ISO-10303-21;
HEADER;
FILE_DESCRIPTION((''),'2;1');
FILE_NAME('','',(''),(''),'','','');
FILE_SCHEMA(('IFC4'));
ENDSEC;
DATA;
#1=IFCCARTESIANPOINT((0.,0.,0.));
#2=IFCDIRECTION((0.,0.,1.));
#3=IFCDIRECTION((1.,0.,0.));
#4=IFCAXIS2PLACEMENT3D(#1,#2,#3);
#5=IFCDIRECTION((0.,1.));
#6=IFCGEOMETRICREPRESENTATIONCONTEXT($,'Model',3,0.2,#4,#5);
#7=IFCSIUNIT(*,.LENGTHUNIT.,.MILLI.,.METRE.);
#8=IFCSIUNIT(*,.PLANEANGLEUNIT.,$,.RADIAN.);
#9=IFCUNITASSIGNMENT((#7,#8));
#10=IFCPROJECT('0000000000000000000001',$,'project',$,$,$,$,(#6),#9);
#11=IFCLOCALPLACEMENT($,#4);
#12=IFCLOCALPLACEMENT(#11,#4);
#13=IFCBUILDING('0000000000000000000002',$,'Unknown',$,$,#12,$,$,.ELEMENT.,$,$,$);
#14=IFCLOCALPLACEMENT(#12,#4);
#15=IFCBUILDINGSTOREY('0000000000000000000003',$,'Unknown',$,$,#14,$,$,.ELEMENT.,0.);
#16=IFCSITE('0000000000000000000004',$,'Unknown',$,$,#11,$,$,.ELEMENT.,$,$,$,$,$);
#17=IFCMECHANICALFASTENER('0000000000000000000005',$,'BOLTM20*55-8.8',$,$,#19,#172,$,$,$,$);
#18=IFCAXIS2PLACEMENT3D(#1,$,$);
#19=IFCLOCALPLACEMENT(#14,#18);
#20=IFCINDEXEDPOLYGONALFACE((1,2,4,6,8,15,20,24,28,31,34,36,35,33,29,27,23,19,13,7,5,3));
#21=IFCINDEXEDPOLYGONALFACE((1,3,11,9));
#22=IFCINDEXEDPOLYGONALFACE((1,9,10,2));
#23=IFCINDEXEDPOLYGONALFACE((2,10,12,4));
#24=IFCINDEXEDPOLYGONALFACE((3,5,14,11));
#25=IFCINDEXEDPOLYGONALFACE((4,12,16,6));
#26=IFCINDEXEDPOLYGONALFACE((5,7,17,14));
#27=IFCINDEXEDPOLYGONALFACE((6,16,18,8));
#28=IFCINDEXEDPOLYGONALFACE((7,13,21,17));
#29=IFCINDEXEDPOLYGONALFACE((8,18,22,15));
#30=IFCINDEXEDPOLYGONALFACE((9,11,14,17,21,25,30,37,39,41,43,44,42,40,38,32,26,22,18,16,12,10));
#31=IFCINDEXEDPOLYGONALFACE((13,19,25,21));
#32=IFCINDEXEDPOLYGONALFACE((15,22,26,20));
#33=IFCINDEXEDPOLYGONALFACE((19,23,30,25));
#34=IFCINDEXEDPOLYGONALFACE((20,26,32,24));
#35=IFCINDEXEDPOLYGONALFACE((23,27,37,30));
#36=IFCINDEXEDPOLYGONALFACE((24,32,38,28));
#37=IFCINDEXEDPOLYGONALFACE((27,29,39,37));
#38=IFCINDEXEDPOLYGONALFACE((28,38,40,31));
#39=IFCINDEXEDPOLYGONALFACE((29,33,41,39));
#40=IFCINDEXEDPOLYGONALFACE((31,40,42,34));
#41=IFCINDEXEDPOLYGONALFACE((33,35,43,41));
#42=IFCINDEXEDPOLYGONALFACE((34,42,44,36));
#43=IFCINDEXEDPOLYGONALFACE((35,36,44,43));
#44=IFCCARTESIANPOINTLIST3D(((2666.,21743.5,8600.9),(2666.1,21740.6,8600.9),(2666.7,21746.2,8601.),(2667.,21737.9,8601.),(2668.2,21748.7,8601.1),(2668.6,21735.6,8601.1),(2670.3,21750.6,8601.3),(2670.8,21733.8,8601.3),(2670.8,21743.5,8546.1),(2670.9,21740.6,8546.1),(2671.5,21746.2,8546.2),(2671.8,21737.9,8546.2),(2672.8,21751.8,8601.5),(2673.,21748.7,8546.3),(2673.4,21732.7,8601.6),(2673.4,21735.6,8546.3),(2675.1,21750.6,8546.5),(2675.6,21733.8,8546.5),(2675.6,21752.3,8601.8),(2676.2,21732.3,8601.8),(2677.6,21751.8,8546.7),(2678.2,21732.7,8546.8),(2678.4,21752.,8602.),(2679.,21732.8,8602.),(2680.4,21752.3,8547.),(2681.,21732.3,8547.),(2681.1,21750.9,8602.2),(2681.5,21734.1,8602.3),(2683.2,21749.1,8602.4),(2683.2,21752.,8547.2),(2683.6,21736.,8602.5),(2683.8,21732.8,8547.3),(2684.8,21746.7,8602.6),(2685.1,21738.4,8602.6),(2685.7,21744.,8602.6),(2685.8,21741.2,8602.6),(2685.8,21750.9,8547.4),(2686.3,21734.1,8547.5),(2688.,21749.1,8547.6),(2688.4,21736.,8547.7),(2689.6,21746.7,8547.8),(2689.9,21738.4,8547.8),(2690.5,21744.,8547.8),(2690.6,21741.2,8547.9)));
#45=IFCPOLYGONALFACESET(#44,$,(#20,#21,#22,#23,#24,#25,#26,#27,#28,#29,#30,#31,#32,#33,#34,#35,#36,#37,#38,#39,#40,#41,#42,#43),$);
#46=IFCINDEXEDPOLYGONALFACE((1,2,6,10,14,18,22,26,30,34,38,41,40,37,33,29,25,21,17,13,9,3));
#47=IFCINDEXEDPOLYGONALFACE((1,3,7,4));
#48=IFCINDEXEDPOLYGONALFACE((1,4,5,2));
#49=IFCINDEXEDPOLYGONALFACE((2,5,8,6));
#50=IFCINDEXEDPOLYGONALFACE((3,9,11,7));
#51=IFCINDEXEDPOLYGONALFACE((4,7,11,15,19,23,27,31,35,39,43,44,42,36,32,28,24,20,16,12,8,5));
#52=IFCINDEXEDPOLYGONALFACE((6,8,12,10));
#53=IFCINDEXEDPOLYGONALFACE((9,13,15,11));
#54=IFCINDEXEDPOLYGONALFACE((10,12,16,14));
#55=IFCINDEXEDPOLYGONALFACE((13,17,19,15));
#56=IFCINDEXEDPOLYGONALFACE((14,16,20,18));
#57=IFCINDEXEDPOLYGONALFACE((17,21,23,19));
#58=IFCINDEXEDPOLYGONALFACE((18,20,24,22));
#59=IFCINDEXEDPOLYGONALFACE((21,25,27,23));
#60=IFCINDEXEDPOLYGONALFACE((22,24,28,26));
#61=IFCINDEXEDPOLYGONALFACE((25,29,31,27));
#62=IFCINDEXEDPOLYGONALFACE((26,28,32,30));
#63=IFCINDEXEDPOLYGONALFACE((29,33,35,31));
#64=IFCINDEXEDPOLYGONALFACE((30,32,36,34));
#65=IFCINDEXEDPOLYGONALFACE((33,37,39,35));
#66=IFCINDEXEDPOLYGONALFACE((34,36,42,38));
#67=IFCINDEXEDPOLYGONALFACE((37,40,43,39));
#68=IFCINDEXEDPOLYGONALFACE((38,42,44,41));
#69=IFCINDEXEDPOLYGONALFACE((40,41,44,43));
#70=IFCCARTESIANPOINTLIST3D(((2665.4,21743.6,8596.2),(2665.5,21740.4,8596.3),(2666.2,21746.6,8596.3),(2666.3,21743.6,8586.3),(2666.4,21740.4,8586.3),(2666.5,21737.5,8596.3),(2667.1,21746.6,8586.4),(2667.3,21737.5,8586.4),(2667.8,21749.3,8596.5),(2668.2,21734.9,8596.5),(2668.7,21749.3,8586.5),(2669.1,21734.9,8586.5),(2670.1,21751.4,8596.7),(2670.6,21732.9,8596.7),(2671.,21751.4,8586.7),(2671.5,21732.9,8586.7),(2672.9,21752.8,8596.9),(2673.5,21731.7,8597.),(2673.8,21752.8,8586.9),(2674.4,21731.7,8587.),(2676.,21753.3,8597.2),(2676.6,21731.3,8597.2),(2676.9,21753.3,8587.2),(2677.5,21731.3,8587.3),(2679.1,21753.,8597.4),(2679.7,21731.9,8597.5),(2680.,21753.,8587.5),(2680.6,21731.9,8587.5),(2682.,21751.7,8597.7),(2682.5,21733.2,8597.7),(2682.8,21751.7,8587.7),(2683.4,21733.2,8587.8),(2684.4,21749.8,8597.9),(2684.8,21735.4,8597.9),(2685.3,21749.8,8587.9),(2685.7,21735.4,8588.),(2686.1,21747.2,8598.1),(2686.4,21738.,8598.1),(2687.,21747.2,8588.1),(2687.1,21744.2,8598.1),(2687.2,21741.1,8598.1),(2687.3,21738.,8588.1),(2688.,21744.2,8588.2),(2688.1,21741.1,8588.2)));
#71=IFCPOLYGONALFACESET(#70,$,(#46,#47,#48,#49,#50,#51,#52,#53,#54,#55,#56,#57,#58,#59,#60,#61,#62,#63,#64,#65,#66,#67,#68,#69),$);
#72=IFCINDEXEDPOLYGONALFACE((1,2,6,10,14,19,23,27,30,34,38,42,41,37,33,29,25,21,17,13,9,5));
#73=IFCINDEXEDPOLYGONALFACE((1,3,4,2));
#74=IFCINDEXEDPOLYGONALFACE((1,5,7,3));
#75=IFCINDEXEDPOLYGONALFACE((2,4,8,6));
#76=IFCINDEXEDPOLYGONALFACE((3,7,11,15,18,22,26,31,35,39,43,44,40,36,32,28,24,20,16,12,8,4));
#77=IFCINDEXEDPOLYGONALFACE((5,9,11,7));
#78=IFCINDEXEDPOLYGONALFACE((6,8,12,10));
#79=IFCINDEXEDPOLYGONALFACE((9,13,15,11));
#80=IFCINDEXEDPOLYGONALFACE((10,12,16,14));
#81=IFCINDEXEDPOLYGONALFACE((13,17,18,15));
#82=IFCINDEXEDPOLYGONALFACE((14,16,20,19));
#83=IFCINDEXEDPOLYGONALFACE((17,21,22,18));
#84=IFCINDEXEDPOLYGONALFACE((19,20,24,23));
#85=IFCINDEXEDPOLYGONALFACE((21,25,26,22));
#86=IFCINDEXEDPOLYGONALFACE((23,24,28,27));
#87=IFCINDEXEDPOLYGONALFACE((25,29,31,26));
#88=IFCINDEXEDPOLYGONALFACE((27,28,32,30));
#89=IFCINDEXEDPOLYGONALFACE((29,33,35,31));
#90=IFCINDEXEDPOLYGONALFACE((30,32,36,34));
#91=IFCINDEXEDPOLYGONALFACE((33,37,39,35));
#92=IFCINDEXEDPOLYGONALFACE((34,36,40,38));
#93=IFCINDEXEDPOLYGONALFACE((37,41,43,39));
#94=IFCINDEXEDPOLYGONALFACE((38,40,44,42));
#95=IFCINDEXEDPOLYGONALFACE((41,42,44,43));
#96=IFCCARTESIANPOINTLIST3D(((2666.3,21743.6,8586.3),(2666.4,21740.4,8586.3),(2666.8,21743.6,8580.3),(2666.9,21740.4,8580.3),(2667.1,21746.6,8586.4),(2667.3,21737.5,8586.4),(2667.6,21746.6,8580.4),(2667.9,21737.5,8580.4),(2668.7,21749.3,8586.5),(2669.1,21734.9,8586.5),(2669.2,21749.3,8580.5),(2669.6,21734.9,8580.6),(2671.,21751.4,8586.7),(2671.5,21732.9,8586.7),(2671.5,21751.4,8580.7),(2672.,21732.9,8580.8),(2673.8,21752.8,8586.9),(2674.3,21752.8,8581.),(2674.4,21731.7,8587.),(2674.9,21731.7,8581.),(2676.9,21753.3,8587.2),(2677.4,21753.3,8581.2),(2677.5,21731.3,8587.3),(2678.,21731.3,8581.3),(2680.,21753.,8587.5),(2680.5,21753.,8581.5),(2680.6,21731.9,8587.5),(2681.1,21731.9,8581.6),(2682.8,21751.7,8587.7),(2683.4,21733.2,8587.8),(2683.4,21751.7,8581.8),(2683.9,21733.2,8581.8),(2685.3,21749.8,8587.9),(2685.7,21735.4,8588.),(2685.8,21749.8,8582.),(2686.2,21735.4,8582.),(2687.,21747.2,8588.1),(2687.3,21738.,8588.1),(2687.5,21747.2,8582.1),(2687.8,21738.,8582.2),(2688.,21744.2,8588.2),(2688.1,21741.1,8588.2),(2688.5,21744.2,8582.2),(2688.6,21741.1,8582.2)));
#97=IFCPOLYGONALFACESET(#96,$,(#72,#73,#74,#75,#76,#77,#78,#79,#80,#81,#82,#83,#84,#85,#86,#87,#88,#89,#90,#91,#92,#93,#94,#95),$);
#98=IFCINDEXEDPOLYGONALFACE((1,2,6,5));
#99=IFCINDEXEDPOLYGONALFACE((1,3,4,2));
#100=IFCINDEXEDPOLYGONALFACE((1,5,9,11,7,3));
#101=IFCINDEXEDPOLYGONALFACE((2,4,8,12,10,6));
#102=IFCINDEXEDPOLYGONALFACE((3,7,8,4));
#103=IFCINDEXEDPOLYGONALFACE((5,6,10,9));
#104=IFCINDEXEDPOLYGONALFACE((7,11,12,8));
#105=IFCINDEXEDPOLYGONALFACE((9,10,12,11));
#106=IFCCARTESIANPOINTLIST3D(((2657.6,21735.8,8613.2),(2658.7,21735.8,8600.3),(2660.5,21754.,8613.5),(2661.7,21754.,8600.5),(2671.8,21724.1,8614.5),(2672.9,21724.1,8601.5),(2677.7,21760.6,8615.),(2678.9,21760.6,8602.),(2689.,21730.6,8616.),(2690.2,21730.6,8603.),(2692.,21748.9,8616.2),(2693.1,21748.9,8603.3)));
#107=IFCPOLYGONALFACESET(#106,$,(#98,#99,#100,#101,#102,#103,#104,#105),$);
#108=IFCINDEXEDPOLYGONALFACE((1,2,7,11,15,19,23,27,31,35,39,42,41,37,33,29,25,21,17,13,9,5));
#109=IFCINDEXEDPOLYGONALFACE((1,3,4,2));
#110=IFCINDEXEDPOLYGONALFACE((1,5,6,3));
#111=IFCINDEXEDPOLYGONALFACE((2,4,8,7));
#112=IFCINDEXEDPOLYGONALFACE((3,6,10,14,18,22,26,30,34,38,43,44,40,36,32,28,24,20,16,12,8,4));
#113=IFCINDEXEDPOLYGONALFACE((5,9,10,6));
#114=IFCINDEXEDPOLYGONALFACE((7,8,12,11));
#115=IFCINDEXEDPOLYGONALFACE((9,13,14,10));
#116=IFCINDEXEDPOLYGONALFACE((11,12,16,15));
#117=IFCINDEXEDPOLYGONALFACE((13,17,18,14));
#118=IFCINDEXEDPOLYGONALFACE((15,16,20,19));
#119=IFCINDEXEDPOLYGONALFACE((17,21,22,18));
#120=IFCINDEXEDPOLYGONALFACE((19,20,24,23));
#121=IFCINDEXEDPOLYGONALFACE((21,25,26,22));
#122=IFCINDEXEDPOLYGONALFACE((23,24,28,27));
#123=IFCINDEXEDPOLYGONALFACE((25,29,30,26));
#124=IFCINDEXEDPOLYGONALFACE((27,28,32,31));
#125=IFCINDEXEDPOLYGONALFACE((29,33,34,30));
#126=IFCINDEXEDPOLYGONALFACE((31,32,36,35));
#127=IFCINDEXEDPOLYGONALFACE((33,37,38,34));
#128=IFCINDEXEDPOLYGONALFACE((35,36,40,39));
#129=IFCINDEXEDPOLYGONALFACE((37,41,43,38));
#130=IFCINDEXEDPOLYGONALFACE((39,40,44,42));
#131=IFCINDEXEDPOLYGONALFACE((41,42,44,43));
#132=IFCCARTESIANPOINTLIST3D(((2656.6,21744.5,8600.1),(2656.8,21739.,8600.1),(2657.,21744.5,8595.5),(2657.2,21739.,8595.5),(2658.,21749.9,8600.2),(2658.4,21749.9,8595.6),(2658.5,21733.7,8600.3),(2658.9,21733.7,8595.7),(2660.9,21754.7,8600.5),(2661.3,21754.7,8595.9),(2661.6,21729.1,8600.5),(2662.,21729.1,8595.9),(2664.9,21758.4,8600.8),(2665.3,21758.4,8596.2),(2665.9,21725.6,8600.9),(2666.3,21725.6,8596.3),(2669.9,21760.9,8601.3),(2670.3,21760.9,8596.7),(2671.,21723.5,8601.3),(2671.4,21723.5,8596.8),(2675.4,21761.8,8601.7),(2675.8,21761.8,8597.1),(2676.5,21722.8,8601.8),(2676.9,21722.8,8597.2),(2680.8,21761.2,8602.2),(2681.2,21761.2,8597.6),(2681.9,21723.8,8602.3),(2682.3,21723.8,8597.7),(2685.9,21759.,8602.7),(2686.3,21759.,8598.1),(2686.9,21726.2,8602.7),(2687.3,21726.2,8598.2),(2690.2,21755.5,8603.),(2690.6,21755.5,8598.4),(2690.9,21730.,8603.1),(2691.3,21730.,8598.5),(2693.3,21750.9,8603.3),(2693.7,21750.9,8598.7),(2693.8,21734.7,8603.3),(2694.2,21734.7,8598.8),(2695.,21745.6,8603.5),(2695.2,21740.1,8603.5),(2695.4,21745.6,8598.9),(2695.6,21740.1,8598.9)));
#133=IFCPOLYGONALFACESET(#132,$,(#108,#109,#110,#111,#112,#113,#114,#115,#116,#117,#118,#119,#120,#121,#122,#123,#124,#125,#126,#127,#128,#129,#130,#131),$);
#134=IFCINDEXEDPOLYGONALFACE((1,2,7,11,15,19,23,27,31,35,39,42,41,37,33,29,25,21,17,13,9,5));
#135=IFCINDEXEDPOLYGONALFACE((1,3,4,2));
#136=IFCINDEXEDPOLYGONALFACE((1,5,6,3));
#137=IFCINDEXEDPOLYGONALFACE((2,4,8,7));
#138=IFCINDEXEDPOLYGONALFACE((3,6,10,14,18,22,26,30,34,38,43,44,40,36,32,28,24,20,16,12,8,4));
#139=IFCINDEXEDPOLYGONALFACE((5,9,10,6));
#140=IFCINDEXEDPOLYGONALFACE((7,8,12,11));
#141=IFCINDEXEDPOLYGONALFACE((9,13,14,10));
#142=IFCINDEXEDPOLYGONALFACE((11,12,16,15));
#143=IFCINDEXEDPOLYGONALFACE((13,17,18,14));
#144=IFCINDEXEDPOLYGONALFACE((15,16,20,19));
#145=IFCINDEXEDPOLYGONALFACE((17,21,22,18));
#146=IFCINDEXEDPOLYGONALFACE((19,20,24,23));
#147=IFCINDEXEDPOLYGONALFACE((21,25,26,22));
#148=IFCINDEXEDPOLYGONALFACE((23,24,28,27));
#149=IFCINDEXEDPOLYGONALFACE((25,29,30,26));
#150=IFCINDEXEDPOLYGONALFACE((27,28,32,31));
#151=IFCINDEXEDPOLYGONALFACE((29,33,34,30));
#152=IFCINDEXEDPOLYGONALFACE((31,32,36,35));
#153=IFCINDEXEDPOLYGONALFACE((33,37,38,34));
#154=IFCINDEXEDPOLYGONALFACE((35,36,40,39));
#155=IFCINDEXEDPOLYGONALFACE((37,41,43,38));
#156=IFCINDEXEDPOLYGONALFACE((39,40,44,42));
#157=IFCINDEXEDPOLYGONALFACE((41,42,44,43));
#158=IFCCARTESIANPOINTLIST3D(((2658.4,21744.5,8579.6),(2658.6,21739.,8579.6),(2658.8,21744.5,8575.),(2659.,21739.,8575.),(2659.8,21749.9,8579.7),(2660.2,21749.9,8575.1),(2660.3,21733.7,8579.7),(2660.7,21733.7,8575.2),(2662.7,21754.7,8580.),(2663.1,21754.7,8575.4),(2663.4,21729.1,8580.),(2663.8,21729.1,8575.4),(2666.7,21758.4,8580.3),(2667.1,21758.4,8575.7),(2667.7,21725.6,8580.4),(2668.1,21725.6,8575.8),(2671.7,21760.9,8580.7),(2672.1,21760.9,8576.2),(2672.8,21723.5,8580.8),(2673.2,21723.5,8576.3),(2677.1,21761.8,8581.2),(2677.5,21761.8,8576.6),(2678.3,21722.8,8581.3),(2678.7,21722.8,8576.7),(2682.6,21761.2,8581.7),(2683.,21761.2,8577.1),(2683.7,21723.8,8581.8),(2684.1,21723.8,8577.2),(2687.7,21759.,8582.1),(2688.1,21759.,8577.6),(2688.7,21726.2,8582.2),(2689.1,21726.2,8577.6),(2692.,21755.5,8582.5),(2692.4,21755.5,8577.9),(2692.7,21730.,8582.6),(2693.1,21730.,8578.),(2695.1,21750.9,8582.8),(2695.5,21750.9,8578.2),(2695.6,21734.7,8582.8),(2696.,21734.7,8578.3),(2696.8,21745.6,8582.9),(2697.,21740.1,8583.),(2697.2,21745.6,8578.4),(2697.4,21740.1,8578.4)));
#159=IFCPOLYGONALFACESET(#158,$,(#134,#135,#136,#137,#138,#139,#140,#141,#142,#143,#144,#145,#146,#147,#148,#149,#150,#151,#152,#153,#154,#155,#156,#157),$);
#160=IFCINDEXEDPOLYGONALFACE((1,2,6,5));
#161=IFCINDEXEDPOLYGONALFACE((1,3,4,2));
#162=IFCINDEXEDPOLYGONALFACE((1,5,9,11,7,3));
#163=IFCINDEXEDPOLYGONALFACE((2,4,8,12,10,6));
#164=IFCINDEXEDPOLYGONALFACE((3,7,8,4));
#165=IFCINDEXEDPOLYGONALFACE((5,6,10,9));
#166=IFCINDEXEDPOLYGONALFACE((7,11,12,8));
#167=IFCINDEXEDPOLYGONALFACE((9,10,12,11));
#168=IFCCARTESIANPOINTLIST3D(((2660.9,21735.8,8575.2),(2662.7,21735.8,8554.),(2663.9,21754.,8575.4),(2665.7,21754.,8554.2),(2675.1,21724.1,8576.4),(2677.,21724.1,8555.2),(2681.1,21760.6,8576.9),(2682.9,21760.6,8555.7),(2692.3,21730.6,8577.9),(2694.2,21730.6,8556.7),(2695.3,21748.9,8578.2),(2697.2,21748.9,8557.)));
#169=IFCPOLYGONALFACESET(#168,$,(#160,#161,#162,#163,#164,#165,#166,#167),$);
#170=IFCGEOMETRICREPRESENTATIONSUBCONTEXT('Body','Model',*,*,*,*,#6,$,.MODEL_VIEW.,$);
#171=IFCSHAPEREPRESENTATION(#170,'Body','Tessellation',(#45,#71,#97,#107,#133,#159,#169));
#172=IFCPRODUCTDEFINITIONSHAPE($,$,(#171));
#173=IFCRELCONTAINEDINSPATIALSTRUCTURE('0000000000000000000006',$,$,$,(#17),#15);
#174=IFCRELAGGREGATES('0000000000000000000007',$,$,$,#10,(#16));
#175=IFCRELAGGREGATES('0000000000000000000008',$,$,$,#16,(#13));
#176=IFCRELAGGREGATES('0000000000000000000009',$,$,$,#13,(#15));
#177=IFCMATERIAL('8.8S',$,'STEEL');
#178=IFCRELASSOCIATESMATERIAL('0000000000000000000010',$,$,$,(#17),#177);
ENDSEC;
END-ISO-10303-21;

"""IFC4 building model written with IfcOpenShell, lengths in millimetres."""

from ifc_helpers import new_model, si_unit, direction, frame, origin_with_axes, place, context, subcontext, project, spatial, line, arc, indexed_curve, outline, extrude, source, transform, mapped, material, element, save


model = new_model("IFC4")

# Units and contexts
model_context = context("Model", 3, precision=0.2, world=origin_with_axes(), true_north=direction((0.0, 1.0)))
body_context = subcontext(model_context, "Body", "Model", "MODEL_VIEW")
ifc_project = project(units=[si_unit("LENGTHUNIT", "METRE", prefix="MILLI"), si_unit("PLANEANGLEUNIT", "RADIAN")], contexts=[model_context])

# Site, building, storey
site_placement = place(None, origin_with_axes())
site = spatial("IfcSite", under=ifc_project, at=site_placement, Name="Unknown", CompositionType="ELEMENT")
building_placement = place(site_placement, origin_with_axes())
building = spatial("IfcBuilding", under=site, at=building_placement, Name="Unknown", CompositionType="ELEMENT")
storey_placement = place(building_placement, origin_with_axes())
storey = spatial("IfcBuildingStorey", under=building, at=storey_placement, Name="Unknown", CompositionType="ELEMENT", Elevation=0.0)

# Mechanical fastener
ifc_material_1 = material(Name="8.8S", Category="STEEL")
shared_shape_1 = source(origin_with_axes(), body_context, "Body", "SweptSolid", [
    extrude(outline(indexed_curve([(10.0, 0.0), (0.0, 10.0), (-10.0, 0.0), (0.0, -10.0)], segments=[arc(1, 2, 3), arc(3, 4, 1)])), frame((0.0, 0.0, 14.6), z_axis=(0.0, 0.0, -1.0), x_axis=(0.0, 1.0, 0.0)), (0.0, 0.0, 1.0), 55.0),
    extrude(outline(indexed_curve([(11.0, 0.0), (0.0, 11.0), (-11.0, 0.0), (0.0, -11.0)], segments=[arc(1, 2, 3), arc(3, 4, 1)])), frame((0.0, 0.0, 10.0), z_axis=(0.0, 0.0, -1.0), x_axis=(0.0, 1.0, 0.0)), (0.0, 0.0, 1.0), 10.0),
    extrude(outline(indexed_curve([(11.0, 0.0), (0.0, 11.0), (-11.0, 0.0), (0.0, -11.0)], segments=[arc(1, 2, 3), arc(3, 4, 1)])), frame((0.0, 0.0, 0.0), z_axis=(0.0, 0.0, -1.0), x_axis=(0.0, 1.0, 0.0)), (0.0, 0.0, 1.0), 6.0),
    extrude(outline(indexed_curve([(18.5, 0.0), (9.2, 16.0), (-9.2, 16.0), (-18.5, 0.0), (-9.2, -16.0), (9.2, -16.0)], segments=[line(1, 2, 3, 4, 5, 6, 1)])), frame((0.0, 0.0, 27.6), z_axis=(0.0, 0.0, -1.0), x_axis=(0.0, 1.0, 0.0)), (0.0, 0.0, 1.0), 13.0),
    extrude(outline(indexed_curve([(19.5, 0.0), (0.0, 19.5), (-19.5, 0.0), (0.0, -19.5)], segments=[arc(1, 2, 3), arc(3, 4, 1)])), frame((0.0, 0.0, 14.6), z_axis=(0.0, 0.0, -1.0), x_axis=(0.0, 1.0, 0.0)), (0.0, 0.0, 1.0), 4.6),
    extrude(outline(indexed_curve([(19.5, 0.0), (0.0, 19.5), (-19.5, 0.0), (0.0, -19.5)], segments=[arc(1, 2, 3), arc(3, 4, 1)])), frame((0.0, 0.0, -6.0), z_axis=(0.0, 0.0, -1.0), x_axis=(0.0, 1.0, 0.0)), (0.0, 0.0, 1.0), 4.6),
    extrude(outline(indexed_curve([(18.5, 0.0), (9.2, 16.0), (-9.2, 16.0), (-18.5, 0.0), (-9.2, -16.0), (9.2, -16.0)], segments=[line(1, 2, 3, 4, 5, 6, 1)])), frame((0.0, 0.0, -10.6), z_axis=(0.0, 0.0, -1.0), x_axis=(0.0, 1.0, 0.0)), (0.0, 0.0, 1.0), 21.3),
])
mechanical_fastener_1_placement = place(storey_placement, frame((2677.2, 21742.3, 8587.2), z_axis=(-0.087156, 0.0, 0.996195), x_axis=(0.630574, 0.774166, 0.055168)))
element("IfcMechanicalFastener", 1, at=mechanical_fastener_1_placement, inside=storey, material=ifc_material_1, Name="BOLTM20*55-8.8", context=body_context, shape_type="MappedRepresentation", body=[
    mapped(shared_shape_1, transform((0.0, 0.0, 0.0))),
])

save(model, "model.ifc")
